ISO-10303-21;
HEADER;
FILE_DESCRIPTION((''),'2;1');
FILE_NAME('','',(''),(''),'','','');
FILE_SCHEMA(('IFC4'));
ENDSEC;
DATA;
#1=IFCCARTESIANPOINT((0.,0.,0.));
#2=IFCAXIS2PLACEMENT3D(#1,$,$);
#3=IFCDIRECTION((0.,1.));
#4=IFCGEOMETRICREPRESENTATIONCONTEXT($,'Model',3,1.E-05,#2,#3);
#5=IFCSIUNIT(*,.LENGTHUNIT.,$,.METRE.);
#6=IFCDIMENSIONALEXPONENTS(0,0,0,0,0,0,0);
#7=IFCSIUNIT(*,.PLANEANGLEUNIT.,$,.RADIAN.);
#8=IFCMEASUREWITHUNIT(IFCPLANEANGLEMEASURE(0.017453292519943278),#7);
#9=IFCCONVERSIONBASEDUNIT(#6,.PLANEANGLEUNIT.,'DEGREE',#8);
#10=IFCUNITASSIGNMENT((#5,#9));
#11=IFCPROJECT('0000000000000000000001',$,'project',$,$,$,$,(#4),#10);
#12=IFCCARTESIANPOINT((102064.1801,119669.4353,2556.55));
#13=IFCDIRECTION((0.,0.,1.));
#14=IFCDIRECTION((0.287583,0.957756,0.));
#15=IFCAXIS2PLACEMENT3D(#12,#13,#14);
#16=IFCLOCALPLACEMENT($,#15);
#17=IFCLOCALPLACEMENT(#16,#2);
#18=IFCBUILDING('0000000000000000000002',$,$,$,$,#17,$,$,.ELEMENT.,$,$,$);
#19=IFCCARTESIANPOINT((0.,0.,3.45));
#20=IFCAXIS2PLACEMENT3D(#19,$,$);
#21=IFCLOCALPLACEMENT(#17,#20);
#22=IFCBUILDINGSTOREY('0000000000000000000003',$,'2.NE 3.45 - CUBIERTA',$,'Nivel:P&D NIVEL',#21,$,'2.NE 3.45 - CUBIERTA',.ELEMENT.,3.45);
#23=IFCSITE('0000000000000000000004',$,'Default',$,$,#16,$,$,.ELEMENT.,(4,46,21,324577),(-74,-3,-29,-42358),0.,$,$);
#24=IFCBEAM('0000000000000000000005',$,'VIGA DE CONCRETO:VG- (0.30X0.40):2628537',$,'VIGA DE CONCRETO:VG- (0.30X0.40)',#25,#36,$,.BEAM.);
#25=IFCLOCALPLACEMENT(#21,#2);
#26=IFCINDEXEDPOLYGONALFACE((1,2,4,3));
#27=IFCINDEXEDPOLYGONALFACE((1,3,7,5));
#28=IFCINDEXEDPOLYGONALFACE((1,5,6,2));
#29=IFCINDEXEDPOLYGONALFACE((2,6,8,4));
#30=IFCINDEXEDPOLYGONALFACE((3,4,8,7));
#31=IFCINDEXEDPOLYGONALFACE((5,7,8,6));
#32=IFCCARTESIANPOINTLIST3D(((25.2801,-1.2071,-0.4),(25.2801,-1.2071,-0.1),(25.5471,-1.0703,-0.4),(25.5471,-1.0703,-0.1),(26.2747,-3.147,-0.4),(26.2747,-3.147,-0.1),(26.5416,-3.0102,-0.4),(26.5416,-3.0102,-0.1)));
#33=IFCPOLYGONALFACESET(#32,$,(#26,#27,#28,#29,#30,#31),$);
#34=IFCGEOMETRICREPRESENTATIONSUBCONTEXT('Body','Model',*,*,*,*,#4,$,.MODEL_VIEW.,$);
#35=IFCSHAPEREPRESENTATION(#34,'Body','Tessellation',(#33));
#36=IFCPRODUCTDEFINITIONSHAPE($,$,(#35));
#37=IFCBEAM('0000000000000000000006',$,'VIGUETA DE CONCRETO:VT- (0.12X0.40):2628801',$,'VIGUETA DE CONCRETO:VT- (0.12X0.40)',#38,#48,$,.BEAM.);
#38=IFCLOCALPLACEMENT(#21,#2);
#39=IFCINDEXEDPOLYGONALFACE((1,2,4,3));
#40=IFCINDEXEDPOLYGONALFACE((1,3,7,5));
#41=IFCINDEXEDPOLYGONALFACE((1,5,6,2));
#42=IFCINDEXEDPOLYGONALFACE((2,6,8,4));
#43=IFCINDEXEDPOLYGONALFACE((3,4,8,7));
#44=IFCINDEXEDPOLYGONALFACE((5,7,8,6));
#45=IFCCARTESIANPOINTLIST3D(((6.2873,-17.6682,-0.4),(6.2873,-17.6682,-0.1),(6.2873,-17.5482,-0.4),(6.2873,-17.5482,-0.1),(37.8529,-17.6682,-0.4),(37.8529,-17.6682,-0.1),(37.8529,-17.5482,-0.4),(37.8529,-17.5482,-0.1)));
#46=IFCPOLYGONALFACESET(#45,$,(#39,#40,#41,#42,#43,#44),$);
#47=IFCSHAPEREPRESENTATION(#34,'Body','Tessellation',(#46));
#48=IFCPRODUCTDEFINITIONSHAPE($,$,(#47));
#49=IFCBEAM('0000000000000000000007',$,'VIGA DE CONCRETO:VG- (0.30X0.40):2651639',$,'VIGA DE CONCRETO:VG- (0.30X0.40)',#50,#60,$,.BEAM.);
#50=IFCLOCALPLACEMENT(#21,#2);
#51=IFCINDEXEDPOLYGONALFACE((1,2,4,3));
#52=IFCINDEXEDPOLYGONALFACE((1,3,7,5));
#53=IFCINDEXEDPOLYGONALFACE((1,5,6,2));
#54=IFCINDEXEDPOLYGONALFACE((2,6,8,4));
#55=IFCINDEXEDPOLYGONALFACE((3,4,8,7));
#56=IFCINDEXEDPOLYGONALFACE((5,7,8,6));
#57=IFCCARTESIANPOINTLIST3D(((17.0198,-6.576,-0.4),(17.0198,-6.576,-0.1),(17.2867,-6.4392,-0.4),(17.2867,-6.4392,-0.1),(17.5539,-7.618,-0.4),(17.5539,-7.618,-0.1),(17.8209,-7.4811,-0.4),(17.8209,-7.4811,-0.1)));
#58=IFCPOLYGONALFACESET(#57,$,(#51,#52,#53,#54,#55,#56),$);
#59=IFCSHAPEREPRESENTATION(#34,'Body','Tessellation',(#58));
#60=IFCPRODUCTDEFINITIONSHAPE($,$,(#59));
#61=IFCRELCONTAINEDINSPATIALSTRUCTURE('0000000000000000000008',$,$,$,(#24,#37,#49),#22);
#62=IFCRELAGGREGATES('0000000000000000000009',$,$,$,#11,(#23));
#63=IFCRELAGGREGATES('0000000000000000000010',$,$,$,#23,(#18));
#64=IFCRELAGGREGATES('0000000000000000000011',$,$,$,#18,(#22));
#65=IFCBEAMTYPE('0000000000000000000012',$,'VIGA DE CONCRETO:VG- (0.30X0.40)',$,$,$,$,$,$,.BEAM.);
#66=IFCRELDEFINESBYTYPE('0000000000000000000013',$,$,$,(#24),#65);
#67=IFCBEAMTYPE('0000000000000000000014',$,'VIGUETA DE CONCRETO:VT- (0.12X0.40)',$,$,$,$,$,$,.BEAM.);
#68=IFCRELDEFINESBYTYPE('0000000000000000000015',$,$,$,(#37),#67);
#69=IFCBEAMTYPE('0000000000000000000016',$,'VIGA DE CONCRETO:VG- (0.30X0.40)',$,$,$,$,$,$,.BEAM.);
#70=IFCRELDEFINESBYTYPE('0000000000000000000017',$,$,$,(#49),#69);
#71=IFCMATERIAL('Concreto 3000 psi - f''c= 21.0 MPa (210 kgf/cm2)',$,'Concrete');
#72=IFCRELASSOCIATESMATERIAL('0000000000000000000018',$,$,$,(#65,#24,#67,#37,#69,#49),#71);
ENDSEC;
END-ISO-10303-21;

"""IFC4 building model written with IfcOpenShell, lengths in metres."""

from ifc_helpers import new_model, entity, si_unit, converted_unit, direction, frame, origin, place, context, subcontext, project, spatial, indexed_curve, outline, extrude, source, transform, mapped, material, type_object, type_shapes, element, save


model = new_model("IFC4")

# Units and contexts
model_context = context("Model", 3, precision=1e-05, world=origin(), true_north=direction((0.0, 1.0)))
body_context = subcontext(model_context, "Body", "Model", "MODEL_VIEW")
ifc_project = project(units=[si_unit("LENGTHUNIT", "METRE"), converted_unit("PLANEANGLEUNIT", "DEGREE", entity("IfcPlaneAngleMeasure", 0.017453292519943278), si_unit("PLANEANGLEUNIT", "RADIAN"), dimensions=[0, 0, 0, 0, 0, 0, 0])], contexts=[model_context])

# Site, building, storey
site_placement = place(None, frame((102064.1801, 119669.4353, 2556.55), z_axis=(0.0, 0.0, 1.0), x_axis=(0.287583, 0.957756, 0.0)))
site = spatial("IfcSite", under=ifc_project, at=site_placement, Name="Default", CompositionType="ELEMENT", RefLatitude=(4, 46, 21, 324577), RefLongitude=(-74, -3, -29, -42358), RefElevation=0.0)
building_placement = place(site_placement, origin())
building = spatial("IfcBuilding", under=site, at=building_placement, CompositionType="ELEMENT")
storey_placement = place(building_placement, frame((0.0, 0.0, 3.45)))
storey = spatial("IfcBuildingStorey", under=building, at=storey_placement, Name="2.NE 3.45 - CUBIERTA", ObjectType="Nivel:P&D NIVEL", LongName="2.NE 3.45 - CUBIERTA", CompositionType="ELEMENT", Elevation=3.45)

# Beams
ifc_material_1 = material(Name="Concreto 3000 psi - f'c= 21.0 MPa (210 kgf/cm2)", Category="Concrete")
beam_type_1 = type_object("IfcBeamType", Name="VIGA DE CONCRETO:VG- (0.30X0.40)", PredefinedType="BEAM", material=ifc_material_1)
shared_shape_1 = source(origin(), body_context, "Body", "SweptSolid", [
    extrude(outline(indexed_curve([(-0.15, -0.15), (0.15, -0.15), (0.15, 0.15), (-0.15, 0.15), (-0.15, -0.15)], self_intersect=False)), frame((26.4081, -3.0786, 3.2), z_axis=(-0.456217, 0.889869, 0.0), x_axis=(0.0, 0.0, 1.0)), (0.0, 0.0, 1.0), 2.18),
])
type_shapes(beam_type_1, [shared_shape_1])
beam_1_placement = place(storey_placement, frame((0.0, 0.0, -3.45)))
element("IfcBeam", 1, at=beam_1_placement, inside=storey, type_object=beam_type_1, material=ifc_material_1, Name="VIGA DE CONCRETO:VG- (0.30X0.40):2628537", ObjectType="VIGA DE CONCRETO:VG- (0.30X0.40)", PredefinedType="BEAM", context=body_context, shape_type="MappedRepresentation", body=[
    mapped(shared_shape_1, transform((0.0, 0.0, 0.0), scale=1.0)),
])
beam_type_2 = type_object("IfcBeamType", Name="VIGUETA DE CONCRETO:VT- (0.12X0.40)", PredefinedType="BEAM", material=ifc_material_1)
shared_shape_2 = source(origin(), body_context, "Body", "SweptSolid", [
    extrude(outline(indexed_curve([(-0.15, -0.06), (0.15, -0.06), (0.15, 0.06), (-0.15, 0.06), (-0.15, -0.06)], self_intersect=False)), frame((37.8529, -17.6082, 3.2), z_axis=(-1.0, 0.0, 0.0), x_axis=(0.0, 0.0, -1.0)), (0.0, 0.0, 1.0), 31.5656),
])
type_shapes(beam_type_2, [shared_shape_2])
beam_2_placement = place(storey_placement, frame((0.0, 0.0, -3.45)))
element("IfcBeam", 2, at=beam_2_placement, inside=storey, type_object=beam_type_2, material=ifc_material_1, Name="VIGUETA DE CONCRETO:VT- (0.12X0.40):2628801", ObjectType="VIGUETA DE CONCRETO:VT- (0.12X0.40)", PredefinedType="BEAM", context=body_context, shape_type="MappedRepresentation", body=[
    mapped(shared_shape_2, transform((0.0, 0.0, 0.0), scale=1.0)),
])
beam_type_3 = type_object("IfcBeamType", Name="VIGA DE CONCRETO:VG- (0.30X0.40)", PredefinedType="BEAM", material=ifc_material_1)
shared_shape_3 = source(origin(), body_context, "Body", "SweptSolid", [
    extrude(outline(indexed_curve([(-0.15, -0.15), (0.15, -0.15), (0.15, 0.15), (-0.15, 0.15), (-0.15, -0.15)], self_intersect=False)), frame((17.6874, -7.5495, 3.2), z_axis=(-0.456217, 0.889869, 0.0), x_axis=(0.0, 0.0, 1.0)), (0.0, 0.0, 1.0), 1.1709),
])
type_shapes(beam_type_3, [shared_shape_3])
beam_3_placement = place(storey_placement, frame((0.0, 0.0, -3.45)))
element("IfcBeam", 3, at=beam_3_placement, inside=storey, type_object=beam_type_3, material=ifc_material_1, Name="VIGA DE CONCRETO:VG- (0.30X0.40):2651639", ObjectType="VIGA DE CONCRETO:VG- (0.30X0.40)", PredefinedType="BEAM", context=body_context, shape_type="MappedRepresentation", body=[
    mapped(shared_shape_3, transform((0.0, 0.0, 0.0), scale=1.0)),
])

save(model, "model.ifc")
